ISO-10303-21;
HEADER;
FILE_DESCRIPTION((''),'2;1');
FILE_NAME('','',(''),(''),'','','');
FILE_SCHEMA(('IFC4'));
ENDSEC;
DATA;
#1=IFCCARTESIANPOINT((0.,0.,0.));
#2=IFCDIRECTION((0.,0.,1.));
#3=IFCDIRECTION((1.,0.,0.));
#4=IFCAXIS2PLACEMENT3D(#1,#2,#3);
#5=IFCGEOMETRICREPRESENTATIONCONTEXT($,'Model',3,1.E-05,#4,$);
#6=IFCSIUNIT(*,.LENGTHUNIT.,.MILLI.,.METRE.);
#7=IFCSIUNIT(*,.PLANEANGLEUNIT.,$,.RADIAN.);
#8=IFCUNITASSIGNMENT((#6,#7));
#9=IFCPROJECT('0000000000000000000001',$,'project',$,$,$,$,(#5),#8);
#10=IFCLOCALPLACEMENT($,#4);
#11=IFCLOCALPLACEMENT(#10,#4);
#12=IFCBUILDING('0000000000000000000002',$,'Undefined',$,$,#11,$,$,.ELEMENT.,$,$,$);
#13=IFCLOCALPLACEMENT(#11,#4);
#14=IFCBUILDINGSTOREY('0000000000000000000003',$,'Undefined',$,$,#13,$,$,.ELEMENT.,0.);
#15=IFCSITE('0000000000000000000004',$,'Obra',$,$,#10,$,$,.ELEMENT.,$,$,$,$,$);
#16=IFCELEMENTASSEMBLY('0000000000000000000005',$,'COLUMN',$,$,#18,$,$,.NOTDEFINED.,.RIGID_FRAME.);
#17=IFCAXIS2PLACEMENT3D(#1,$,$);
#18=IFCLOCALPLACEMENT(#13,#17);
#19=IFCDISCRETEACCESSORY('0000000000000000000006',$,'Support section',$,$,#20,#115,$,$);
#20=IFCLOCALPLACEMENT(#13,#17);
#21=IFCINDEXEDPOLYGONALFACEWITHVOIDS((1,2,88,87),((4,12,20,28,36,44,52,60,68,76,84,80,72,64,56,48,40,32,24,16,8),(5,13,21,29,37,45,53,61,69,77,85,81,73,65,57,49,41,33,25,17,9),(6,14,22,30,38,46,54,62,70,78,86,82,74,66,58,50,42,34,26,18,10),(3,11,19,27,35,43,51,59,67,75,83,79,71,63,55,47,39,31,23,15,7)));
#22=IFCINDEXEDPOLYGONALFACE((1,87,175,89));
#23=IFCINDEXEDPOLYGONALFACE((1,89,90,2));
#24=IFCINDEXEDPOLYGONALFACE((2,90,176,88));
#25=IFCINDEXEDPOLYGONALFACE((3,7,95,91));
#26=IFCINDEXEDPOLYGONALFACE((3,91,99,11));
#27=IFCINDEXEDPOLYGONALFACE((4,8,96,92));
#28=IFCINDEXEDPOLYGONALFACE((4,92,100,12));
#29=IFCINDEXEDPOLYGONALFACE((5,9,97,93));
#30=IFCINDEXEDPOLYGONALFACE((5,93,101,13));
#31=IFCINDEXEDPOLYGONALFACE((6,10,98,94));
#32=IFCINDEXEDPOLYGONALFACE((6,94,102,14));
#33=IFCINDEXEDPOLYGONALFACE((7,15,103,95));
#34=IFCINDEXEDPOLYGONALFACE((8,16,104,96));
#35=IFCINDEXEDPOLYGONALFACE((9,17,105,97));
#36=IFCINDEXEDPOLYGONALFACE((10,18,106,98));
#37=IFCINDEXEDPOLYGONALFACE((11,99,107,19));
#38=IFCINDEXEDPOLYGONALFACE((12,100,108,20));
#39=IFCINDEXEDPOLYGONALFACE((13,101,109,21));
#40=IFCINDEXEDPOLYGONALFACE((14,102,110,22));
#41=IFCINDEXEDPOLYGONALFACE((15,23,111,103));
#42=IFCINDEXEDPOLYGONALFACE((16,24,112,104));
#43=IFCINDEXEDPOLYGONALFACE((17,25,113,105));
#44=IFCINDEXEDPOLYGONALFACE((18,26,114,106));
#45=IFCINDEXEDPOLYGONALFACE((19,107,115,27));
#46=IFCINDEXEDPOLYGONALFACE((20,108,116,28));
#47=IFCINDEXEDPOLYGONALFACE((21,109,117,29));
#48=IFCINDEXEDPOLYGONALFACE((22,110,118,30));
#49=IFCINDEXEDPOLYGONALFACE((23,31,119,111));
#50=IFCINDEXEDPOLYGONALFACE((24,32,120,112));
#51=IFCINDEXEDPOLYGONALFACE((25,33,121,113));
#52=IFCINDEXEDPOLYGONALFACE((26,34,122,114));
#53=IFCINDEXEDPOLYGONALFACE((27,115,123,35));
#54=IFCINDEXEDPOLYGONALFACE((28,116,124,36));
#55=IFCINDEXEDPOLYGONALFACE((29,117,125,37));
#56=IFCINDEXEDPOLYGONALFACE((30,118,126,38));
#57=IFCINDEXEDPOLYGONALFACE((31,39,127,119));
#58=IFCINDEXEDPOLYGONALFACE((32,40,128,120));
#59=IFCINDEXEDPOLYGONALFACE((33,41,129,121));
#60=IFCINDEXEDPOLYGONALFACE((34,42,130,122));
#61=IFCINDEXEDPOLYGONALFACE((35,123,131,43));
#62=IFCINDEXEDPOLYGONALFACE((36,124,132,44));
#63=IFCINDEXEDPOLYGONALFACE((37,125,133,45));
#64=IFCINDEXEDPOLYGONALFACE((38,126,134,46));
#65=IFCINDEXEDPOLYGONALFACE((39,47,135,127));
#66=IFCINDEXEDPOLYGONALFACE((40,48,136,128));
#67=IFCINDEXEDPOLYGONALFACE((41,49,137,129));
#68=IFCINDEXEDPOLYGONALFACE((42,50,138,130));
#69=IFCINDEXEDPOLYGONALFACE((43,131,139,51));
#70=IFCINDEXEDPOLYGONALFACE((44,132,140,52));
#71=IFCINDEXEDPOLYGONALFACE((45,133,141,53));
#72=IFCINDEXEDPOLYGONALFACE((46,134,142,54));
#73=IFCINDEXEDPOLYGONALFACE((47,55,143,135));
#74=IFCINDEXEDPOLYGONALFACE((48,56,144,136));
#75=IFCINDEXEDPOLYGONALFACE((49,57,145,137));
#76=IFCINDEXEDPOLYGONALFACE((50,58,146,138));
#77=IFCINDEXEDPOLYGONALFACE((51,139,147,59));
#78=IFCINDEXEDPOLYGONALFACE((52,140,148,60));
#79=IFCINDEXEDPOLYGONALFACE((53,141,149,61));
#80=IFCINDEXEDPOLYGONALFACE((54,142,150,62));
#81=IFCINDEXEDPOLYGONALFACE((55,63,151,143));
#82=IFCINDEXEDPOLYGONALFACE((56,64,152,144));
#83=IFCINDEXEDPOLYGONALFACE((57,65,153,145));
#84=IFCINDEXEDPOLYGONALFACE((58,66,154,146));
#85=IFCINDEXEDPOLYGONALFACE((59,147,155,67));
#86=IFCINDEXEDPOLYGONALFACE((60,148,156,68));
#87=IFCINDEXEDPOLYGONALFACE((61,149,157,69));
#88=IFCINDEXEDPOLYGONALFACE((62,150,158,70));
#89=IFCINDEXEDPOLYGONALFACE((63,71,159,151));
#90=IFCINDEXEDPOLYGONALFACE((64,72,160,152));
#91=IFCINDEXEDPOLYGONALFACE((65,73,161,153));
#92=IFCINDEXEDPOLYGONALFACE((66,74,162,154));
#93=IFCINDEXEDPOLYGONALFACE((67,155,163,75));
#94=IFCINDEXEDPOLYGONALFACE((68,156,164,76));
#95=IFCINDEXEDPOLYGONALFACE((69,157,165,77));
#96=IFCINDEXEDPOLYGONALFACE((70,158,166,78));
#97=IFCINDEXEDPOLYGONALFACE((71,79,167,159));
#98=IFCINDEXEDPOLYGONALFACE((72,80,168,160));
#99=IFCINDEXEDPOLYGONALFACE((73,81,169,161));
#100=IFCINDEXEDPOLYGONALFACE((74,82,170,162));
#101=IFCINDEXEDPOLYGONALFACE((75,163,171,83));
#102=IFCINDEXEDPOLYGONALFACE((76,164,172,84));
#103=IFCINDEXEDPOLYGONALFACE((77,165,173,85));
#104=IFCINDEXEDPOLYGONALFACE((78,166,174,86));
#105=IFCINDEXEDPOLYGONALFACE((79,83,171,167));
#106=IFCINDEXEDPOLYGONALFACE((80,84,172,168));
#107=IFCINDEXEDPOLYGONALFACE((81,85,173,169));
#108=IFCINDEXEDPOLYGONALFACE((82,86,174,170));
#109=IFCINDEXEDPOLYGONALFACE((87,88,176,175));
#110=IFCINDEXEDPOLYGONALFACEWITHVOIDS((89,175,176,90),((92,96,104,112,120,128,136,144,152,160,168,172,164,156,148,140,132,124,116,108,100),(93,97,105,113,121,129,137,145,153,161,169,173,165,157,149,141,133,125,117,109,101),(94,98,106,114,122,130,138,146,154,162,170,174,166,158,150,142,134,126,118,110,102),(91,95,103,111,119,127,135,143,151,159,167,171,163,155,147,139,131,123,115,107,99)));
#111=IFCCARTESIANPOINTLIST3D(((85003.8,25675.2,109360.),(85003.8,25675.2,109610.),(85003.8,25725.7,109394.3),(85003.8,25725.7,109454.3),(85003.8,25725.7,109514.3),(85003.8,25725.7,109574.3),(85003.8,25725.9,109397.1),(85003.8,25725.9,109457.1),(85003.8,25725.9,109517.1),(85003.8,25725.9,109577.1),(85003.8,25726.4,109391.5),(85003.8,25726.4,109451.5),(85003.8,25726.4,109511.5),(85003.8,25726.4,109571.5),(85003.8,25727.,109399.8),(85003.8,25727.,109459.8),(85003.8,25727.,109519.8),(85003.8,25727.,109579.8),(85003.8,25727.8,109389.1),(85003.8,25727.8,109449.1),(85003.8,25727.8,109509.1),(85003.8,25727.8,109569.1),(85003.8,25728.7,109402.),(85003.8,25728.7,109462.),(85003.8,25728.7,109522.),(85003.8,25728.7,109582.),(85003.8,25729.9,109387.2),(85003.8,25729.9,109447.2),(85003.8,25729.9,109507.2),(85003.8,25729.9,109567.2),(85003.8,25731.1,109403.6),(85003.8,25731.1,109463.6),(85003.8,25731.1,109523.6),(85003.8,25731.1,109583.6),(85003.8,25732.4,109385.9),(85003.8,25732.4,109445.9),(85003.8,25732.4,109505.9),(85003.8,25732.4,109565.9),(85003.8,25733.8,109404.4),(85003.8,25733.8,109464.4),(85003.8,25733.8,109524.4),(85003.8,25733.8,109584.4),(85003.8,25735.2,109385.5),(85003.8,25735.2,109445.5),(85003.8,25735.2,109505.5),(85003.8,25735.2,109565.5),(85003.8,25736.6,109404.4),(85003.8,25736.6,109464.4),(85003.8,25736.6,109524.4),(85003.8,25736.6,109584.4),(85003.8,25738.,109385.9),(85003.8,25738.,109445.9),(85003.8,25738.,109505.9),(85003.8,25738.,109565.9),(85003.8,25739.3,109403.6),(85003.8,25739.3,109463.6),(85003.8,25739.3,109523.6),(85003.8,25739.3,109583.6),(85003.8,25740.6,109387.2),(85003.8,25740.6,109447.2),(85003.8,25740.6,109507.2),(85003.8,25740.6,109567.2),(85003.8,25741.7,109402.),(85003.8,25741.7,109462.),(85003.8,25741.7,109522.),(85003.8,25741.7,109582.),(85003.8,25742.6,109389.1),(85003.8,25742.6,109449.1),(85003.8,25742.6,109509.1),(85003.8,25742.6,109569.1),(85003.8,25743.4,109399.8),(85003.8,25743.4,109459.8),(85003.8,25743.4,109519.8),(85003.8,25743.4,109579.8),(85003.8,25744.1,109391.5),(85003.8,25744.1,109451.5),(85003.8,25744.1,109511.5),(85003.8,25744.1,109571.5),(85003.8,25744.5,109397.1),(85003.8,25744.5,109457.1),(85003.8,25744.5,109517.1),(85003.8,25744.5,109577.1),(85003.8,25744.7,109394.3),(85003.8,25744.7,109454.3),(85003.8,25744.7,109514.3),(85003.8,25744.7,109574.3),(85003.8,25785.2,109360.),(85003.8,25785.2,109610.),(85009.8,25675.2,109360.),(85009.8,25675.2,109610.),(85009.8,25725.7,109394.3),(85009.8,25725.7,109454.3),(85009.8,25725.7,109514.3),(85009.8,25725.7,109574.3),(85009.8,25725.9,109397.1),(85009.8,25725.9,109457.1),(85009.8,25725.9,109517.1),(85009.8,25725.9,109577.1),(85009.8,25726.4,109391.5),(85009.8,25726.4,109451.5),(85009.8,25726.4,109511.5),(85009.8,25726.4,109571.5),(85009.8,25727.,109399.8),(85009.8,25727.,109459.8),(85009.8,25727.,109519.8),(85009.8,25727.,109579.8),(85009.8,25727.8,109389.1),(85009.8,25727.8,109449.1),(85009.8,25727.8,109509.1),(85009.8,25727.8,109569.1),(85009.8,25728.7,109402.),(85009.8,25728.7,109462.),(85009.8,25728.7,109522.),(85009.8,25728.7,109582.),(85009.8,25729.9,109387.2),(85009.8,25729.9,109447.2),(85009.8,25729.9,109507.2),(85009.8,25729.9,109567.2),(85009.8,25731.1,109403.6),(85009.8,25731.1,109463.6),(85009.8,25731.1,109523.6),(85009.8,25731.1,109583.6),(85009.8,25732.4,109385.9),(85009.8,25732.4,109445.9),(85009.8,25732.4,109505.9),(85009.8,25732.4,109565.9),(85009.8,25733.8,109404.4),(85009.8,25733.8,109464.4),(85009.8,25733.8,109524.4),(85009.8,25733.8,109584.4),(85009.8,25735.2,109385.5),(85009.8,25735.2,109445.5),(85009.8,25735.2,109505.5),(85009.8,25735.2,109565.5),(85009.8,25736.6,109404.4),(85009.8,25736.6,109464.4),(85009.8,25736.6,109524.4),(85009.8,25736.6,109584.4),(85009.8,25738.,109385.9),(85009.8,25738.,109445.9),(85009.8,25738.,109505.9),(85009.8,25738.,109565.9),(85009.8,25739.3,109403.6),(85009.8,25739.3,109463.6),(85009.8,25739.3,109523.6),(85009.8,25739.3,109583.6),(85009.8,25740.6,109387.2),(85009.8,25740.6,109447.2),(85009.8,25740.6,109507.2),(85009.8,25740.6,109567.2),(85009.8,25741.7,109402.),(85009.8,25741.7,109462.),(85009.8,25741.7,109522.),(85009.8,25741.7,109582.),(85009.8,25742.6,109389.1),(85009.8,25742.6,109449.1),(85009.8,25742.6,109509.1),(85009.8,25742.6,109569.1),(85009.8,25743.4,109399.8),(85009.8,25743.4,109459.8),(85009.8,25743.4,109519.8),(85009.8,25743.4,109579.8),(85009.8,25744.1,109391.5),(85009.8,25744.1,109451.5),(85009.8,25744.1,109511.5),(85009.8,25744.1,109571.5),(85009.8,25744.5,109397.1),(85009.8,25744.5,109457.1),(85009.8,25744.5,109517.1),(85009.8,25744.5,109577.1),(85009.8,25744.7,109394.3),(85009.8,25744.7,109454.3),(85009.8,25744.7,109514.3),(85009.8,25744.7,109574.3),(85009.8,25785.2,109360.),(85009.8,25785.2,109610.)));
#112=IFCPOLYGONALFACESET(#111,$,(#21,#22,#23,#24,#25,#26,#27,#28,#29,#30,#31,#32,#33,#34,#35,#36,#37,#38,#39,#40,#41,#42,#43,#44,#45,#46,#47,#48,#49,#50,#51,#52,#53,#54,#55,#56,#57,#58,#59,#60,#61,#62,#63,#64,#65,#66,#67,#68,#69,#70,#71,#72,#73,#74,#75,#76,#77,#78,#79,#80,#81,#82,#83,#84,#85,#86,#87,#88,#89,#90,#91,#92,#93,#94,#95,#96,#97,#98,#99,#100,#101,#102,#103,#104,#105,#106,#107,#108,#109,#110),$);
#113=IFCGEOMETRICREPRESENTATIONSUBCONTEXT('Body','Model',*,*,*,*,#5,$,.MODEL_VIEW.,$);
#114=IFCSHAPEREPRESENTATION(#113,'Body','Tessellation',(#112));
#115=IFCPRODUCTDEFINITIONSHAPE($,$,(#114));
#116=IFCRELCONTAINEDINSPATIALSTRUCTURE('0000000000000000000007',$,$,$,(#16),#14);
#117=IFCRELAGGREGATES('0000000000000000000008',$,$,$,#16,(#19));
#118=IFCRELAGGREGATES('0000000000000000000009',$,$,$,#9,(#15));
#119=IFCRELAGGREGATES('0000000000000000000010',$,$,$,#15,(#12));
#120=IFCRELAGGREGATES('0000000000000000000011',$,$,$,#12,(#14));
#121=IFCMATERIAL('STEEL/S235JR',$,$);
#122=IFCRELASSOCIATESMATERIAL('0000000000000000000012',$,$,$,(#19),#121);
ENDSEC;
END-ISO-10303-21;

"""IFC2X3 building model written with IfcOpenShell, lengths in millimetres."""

from ifc_helpers import new_model, si_unit, frame, origin_with_axes, origin_2d_with_axis, place, context, subcontext, project, spatial, rectangle, circle, extrude, source, transform, mapped, material, element, aggregate, save


model = new_model("IFC2X3")

# Units and contexts
model_context = context("Model", 3, precision=1e-05, world=origin_with_axes())
body_context = subcontext(model_context, "Body", "Model", "MODEL_VIEW")
ifc_project = project(units=[si_unit("LENGTHUNIT", "METRE", prefix="MILLI"), si_unit("PLANEANGLEUNIT", "RADIAN")], contexts=[model_context])

# Site, building, storey
site_placement = place(None, origin_with_axes())
site = spatial("IfcSite", under=ifc_project, at=site_placement, Name="Obra", CompositionType="ELEMENT")
building_placement = place(site_placement, origin_with_axes())
building = spatial("IfcBuilding", under=site, at=building_placement, Name="Undefined", CompositionType="ELEMENT")
storey_placement = place(building_placement, origin_with_axes())
storey = spatial("IfcBuildingStorey", under=building, at=storey_placement, Name="Undefined", CompositionType="ELEMENT", Elevation=0.0)

# Shared definitions
ifc_material_1 = material(Name="STEEL/S235JR")

# Element assembly, discrete accessory, opening
assembly_1_placement = place(storey_placement, origin_with_axes())
assembly_1 = element("IfcElementAssembly", 1, at=assembly_1_placement, inside=storey, Name="COLUMN", AssemblyPlace="NOTDEFINED", PredefinedType="RIGID_FRAME")
shared_shape_1 = source(origin_with_axes(), body_context, "Body", "SweptSolid", [
    extrude(circle(Radius=9.5, at=origin_2d_with_axis()), frame((0.0, -9.8, 0.0), z_axis=(0.0, 1.0, 0.0), x_axis=(1.0, 0.0, 0.0)), (0.0, 0.0, 1.0), 6.2),
])
discrete_accessory_1_placement = place(assembly_1_placement, frame((85006.8, 25730.2, 109360.0), z_axis=(0.0, 0.0, 1.0), x_axis=(0.0, -1.0, 0.0)))
discrete_accessory_1 = element("IfcDiscreteAccessory", 2, at=discrete_accessory_1_placement, material=ifc_material_1, Name="Support section", context=body_context, shape_type="SweptSolid", body=[
    extrude(rectangle(XDim=6.0, YDim=110.0, at=origin_2d_with_axis()), frame((0.0, 0.0, 250.0), z_axis=(0.0, 0.0, -1.0), x_axis=(0.0, 1.0, 0.0)), (0.0, 0.0, 1.0), 250.0),
])
opening_1_placement = place(assembly_1_placement, frame((85000.0, 25685.2, 109650.0), z_axis=(0.0, 1.0, 0.0), x_axis=(0.0, 0.0, -1.0)))
element("IfcOpeningElement", 3, at=opening_1_placement, cuts=discrete_accessory_1, ObjectType="Opening", context=body_context, shape_type="MappedRepresentation", body=[
    mapped(shared_shape_1, transform((75.0, 0.0, 50.0))),
    mapped(shared_shape_1, transform((135.0, 0.0, 50.0))),
    mapped(shared_shape_1, transform((195.0, 0.0, 50.0))),
    mapped(shared_shape_1, transform((255.0, 0.0, 50.0))),
])
aggregate(assembly_1, [discrete_accessory_1])

save(model, "model.ifc")
